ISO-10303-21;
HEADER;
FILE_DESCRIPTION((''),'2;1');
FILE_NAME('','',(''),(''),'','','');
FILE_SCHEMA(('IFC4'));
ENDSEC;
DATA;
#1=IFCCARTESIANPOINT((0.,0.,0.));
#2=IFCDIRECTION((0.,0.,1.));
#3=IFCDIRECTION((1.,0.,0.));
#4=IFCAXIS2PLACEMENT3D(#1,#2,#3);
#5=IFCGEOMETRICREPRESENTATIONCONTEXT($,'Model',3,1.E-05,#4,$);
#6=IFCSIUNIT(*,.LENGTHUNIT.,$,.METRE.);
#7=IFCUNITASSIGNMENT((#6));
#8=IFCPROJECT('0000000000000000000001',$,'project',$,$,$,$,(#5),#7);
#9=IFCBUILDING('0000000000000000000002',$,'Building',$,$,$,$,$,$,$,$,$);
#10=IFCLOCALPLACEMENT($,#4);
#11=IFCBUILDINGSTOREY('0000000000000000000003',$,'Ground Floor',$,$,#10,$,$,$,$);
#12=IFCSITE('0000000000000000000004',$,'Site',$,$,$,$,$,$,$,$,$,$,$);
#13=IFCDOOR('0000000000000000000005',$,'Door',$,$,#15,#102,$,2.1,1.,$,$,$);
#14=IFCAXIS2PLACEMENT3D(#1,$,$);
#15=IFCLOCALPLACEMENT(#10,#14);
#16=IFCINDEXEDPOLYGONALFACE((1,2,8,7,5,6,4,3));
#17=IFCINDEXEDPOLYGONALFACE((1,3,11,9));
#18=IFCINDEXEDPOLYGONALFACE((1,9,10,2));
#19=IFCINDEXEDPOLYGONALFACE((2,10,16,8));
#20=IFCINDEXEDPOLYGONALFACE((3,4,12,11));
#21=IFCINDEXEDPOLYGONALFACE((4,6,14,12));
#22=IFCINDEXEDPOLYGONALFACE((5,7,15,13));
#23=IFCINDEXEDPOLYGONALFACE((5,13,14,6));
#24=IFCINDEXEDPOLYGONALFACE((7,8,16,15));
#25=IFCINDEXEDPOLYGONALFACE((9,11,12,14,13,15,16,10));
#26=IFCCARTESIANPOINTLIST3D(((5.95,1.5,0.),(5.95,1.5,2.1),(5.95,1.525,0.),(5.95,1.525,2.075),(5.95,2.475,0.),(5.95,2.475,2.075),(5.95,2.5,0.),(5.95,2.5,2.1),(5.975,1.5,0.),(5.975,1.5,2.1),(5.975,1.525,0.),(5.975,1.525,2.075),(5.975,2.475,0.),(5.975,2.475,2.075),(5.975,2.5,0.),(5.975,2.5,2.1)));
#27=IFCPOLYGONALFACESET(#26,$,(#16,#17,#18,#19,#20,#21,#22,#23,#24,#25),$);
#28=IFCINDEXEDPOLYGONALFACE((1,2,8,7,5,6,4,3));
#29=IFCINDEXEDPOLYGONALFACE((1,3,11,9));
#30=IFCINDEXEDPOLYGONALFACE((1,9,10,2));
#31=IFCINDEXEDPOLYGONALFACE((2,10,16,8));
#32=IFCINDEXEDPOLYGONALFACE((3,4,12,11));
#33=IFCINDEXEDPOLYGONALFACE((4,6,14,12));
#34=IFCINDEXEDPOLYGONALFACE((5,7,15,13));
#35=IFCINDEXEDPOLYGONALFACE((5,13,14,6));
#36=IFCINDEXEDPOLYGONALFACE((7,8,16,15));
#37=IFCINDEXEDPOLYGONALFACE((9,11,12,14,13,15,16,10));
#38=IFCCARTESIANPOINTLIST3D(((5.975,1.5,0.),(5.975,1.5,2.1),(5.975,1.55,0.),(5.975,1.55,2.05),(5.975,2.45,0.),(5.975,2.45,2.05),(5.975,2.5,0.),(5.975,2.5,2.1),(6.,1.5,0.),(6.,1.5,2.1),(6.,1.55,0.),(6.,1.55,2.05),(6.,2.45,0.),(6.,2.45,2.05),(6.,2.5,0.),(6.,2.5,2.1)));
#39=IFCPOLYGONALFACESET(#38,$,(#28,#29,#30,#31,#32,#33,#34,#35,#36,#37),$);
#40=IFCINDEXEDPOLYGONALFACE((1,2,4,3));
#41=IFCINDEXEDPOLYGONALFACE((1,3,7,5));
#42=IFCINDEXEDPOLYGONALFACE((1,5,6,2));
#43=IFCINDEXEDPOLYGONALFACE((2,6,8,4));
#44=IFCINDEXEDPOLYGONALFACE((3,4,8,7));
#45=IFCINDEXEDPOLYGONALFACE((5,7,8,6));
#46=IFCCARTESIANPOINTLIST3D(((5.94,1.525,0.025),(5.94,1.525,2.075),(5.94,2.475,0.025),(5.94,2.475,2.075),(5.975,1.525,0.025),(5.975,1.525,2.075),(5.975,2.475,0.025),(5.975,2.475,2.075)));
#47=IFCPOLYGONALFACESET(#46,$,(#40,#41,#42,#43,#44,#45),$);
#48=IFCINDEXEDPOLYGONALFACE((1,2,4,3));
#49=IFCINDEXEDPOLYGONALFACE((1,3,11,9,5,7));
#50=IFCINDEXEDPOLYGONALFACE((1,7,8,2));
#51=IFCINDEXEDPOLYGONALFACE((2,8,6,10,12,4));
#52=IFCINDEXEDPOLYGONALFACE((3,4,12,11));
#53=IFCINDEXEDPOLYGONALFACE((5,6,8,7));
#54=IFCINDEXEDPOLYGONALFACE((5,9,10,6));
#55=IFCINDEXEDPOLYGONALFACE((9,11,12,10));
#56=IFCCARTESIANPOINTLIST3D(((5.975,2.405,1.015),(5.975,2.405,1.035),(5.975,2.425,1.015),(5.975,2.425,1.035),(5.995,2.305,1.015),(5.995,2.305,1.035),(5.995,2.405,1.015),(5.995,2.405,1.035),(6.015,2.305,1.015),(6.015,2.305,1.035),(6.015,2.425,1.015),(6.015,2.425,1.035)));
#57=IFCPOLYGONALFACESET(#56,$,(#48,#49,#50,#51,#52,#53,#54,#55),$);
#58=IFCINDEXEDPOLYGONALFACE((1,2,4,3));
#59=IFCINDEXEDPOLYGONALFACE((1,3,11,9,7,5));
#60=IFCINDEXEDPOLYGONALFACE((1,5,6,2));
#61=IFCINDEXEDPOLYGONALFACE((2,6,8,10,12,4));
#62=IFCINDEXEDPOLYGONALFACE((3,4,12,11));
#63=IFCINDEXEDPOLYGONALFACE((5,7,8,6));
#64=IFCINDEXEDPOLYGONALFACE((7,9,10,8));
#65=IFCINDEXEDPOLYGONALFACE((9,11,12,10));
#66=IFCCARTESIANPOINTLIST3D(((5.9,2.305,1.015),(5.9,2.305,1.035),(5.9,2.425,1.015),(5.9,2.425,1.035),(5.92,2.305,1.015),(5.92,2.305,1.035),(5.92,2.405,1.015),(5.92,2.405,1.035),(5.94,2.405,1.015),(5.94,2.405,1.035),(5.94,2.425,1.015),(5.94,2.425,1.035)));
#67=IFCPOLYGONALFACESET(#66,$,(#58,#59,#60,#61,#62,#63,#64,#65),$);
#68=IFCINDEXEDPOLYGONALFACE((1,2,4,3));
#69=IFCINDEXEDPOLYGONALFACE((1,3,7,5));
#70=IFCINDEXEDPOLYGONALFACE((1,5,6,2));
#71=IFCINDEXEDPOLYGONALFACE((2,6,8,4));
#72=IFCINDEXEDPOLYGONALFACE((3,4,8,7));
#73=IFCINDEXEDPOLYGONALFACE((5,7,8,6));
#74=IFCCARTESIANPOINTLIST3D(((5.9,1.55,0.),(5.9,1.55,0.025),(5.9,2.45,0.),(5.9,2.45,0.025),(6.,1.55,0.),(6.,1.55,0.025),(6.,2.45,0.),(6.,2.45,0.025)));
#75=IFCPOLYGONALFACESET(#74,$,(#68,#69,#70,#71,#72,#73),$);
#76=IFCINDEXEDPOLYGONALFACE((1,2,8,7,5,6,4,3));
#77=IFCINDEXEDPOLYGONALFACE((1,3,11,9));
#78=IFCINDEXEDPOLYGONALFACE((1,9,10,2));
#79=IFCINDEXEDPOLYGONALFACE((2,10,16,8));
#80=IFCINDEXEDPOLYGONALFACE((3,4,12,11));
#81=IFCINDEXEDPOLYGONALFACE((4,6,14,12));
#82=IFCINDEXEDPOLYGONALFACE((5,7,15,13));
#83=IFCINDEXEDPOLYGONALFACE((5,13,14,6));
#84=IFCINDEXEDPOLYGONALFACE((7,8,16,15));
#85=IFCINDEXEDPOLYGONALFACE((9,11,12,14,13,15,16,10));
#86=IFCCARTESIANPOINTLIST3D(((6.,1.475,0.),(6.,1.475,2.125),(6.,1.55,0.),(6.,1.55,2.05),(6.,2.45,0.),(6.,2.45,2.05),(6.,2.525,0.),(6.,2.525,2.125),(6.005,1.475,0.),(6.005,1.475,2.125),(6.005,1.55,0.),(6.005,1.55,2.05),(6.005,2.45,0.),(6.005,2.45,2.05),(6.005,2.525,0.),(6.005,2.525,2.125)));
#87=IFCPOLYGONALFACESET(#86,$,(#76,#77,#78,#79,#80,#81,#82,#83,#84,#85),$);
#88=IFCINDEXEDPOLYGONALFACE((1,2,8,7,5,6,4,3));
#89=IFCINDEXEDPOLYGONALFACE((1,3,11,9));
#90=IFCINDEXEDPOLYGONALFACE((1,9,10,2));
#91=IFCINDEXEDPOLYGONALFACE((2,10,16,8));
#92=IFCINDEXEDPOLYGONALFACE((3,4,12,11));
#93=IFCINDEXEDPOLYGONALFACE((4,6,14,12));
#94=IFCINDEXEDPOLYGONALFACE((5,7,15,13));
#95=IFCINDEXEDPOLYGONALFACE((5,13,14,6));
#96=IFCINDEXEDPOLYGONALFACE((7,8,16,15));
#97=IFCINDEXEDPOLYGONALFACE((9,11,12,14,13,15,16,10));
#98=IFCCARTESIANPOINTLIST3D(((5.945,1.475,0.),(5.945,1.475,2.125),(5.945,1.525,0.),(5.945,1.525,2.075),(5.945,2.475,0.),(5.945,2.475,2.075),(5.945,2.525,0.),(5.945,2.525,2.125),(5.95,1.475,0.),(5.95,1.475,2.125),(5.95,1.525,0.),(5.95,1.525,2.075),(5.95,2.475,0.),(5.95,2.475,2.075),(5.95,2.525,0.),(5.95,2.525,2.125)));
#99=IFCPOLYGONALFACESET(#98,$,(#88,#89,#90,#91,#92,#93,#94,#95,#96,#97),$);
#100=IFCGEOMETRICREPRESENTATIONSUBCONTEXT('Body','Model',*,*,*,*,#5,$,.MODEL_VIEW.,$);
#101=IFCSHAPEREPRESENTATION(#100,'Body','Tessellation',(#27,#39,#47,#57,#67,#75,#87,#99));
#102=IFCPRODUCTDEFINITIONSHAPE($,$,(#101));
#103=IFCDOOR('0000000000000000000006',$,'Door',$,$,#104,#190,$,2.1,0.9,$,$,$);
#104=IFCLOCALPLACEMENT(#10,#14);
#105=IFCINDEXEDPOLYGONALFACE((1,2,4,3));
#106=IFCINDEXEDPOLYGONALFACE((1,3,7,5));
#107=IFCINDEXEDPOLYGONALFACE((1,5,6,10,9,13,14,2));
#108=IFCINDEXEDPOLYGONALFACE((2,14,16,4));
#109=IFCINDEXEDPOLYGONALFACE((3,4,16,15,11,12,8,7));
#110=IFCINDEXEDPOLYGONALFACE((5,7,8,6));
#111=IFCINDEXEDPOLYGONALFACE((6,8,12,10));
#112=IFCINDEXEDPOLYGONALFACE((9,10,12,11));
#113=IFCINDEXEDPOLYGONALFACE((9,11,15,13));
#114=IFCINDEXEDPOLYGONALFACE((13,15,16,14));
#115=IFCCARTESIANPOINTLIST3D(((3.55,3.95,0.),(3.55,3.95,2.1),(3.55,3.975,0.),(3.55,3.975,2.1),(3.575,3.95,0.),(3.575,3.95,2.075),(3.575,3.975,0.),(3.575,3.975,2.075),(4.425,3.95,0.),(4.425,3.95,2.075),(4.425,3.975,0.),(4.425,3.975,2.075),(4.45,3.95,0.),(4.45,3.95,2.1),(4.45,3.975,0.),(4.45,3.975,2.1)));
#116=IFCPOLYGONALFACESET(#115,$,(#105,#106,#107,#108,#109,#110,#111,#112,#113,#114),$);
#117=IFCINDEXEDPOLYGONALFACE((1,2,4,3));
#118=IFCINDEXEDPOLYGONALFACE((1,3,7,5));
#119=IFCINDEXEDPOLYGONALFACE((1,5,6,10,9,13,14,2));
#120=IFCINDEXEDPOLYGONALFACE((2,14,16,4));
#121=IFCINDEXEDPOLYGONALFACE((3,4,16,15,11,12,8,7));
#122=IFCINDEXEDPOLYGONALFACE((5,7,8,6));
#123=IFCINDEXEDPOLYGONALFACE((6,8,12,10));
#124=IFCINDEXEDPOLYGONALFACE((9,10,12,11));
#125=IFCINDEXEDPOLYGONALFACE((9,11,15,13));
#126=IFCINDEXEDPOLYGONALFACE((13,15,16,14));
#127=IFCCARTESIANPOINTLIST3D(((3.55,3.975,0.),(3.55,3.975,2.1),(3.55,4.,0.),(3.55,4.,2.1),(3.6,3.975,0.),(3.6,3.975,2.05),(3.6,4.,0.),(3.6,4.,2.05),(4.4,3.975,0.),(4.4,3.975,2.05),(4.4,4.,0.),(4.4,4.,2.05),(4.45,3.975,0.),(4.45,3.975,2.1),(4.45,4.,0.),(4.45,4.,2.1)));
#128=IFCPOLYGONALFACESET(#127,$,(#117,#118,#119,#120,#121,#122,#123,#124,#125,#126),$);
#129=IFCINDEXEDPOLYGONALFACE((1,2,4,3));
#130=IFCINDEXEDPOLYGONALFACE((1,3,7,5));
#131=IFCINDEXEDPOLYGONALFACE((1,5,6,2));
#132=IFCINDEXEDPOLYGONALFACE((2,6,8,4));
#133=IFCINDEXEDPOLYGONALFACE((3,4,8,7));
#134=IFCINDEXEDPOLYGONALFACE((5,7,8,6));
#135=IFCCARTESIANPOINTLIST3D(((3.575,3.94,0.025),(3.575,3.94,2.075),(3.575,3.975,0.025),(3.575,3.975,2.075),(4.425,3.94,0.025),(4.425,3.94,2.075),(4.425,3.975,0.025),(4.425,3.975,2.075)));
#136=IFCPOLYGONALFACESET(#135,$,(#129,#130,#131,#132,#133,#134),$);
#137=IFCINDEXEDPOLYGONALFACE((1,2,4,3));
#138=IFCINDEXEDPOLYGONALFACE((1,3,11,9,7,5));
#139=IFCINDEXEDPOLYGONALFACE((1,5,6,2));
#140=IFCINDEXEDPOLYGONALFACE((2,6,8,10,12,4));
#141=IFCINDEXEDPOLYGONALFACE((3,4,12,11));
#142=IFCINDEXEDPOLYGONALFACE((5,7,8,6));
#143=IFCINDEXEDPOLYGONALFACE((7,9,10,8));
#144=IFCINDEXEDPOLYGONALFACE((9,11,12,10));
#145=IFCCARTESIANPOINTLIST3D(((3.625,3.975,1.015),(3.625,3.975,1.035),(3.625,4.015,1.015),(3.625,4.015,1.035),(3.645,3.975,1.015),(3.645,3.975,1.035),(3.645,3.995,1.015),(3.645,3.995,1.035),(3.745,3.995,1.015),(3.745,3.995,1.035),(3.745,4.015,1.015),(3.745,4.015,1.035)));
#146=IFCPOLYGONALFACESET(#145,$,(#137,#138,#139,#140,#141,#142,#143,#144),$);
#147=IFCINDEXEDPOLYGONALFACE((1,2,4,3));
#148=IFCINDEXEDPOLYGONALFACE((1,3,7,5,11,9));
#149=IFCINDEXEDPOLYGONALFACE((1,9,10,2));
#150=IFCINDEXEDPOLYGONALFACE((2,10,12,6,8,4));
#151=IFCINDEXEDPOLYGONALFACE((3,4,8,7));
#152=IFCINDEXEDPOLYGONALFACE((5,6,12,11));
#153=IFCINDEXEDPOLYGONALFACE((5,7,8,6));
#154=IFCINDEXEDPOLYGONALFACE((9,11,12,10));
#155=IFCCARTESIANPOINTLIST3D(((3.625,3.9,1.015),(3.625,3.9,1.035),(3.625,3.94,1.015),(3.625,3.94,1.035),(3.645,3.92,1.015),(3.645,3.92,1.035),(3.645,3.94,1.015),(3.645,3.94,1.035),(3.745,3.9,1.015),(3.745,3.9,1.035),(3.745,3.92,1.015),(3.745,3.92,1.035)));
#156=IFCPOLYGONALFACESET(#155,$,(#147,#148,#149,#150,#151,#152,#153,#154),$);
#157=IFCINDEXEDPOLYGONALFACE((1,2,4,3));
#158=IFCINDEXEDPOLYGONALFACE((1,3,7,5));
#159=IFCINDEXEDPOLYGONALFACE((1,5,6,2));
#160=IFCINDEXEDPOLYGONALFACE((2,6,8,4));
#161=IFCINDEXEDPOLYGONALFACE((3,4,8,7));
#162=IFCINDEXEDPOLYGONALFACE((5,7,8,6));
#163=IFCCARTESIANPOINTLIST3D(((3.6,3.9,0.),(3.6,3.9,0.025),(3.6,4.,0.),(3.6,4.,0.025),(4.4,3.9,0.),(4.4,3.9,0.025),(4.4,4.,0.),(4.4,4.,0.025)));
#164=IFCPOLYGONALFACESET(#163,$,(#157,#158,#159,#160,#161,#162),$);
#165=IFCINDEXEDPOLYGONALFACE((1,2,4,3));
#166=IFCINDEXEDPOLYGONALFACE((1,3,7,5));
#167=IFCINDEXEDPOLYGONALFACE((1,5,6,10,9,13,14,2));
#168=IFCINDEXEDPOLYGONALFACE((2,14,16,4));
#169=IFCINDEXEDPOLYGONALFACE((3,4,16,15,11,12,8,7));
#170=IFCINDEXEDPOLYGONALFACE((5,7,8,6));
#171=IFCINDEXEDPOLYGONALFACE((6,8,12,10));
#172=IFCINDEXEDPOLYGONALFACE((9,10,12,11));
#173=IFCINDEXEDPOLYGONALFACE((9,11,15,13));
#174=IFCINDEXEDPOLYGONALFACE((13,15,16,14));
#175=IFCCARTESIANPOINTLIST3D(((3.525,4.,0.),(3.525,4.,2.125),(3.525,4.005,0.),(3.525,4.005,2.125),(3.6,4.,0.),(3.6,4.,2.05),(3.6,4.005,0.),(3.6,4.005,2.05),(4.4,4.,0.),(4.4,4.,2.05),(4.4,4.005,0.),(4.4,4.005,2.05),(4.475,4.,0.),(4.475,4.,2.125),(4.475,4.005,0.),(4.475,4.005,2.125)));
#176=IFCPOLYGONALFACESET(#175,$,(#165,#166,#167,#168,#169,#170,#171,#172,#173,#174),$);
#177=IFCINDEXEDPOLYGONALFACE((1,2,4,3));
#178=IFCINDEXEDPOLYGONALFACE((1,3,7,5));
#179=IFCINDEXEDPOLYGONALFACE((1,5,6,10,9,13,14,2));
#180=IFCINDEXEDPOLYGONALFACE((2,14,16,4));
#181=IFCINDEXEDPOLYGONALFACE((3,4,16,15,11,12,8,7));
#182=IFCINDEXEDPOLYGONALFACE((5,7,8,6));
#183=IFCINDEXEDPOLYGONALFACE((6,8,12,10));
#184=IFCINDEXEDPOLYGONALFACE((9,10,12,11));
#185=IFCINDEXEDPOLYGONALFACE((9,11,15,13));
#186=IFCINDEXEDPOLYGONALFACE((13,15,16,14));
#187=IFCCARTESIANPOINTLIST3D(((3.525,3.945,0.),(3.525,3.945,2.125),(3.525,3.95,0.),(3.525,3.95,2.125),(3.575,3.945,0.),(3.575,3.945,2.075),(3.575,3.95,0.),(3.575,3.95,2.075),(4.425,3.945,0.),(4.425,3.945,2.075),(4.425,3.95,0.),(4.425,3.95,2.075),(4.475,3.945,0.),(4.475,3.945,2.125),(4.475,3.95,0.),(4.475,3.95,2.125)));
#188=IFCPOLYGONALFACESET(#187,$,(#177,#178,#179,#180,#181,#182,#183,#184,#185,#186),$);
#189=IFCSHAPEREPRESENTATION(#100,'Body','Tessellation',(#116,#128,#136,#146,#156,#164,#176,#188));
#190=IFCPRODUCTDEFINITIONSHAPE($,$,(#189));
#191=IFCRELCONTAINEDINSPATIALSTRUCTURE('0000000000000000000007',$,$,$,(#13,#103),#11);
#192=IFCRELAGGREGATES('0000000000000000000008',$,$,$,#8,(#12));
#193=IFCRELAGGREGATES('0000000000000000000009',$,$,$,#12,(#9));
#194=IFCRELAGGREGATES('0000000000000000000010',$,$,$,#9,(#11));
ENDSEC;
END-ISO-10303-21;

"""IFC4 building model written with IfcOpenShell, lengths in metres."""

from ifc_helpers import new_model, si_unit, frame, origin_with_axes, place, context, subcontext, project, spatial, line, indexed_curve, outline, extrude, element, save


model = new_model("IFC4")

# Units and contexts
model_context = context("Model", 3, precision=1e-05, world=origin_with_axes())
body_context = subcontext(model_context, "Body", "Model", "MODEL_VIEW")
ifc_project = project(units=[si_unit("LENGTHUNIT", "METRE")], contexts=[model_context])

# Site, building, storey
site = spatial("IfcSite", under=ifc_project, Name="Site")
building = spatial("IfcBuilding", under=site, Name="Building")
storey_placement = place(None, origin_with_axes())
storey = spatial("IfcBuildingStorey", under=building, at=storey_placement, Name="Ground Floor")

# Doors
door_1_placement = place(storey_placement, frame((6.0, 1.5, 0.0), z_axis=(0.0, 0.0, 1.0), x_axis=(0.0, 1.0, 0.0)))
element("IfcDoor", 1, at=door_1_placement, inside=storey, Name="Door", OverallHeight=2.1, OverallWidth=1.0, context=body_context, shape_type="SweptSolid", body=[
    extrude(outline(indexed_curve([(0.0, 0.0), (0.0, 2.1), (1.0, 2.1), (1.0, 0.0), (0.975, 0.0), (0.975, 2.075), (0.025, 2.075), (0.025, 0.0)], segments=[line(1, 2, 3, 4, 5, 6, 7, 8, 1)])), frame((0.0, 0.025, 0.0), z_axis=(0.0, -1.0, 0.0), x_axis=(1.0, 0.0, 0.0)), (0.0, 0.0, -1.0), 0.025),
    extrude(outline(indexed_curve([(0.0, 0.0), (0.0, 2.1), (1.0, 2.1), (1.0, 0.0), (0.95, 0.0), (0.95, 2.05), (0.05, 2.05), (0.05, 0.0)], segments=[line(1, 2, 3, 4, 5, 6, 7, 8, 1)])), frame((0.0, 0.0, 0.0), z_axis=(0.0, -1.0, 0.0), x_axis=(1.0, 0.0, 0.0)), (0.0, 0.0, -1.0), 0.025),
    extrude(outline(indexed_curve([(0.0, 0.0), (0.95, 0.0), (0.95, 0.035), (0.0, 0.035)], segments=[line(1, 2, 3, 4, 1)])), frame((0.025, 0.025, 0.025), z_axis=(0.0, 0.0, 1.0), x_axis=(1.0, 0.0, 0.0)), (0.0, 0.0, 1.0), 2.05),
    extrude(outline(indexed_curve([(0.0, 0.0), (0.0, -0.04), (-0.12, -0.04), (-0.12, -0.02), (-0.02, -0.02), (-0.02, 0.0)], segments=[line(1, 2, 3, 4, 5, 6, 1)])), frame((0.925, 0.025, 1.015), z_axis=(0.0, 0.0, 1.0), x_axis=(1.0, 0.0, 0.0)), (0.0, 0.0, 1.0), 0.02),
    extrude(outline(indexed_curve([(0.0, 0.0), (0.0, 0.04), (-0.12, 0.04), (-0.12, 0.02), (-0.02, 0.02), (-0.02, 0.0)], segments=[line(1, 2, 3, 4, 5, 6, 1)])), frame((0.925, 0.06, 1.015), z_axis=(0.0, 0.0, 1.0), x_axis=(1.0, 0.0, 0.0)), (0.0, 0.0, 1.0), 0.02),
    extrude(outline(indexed_curve([(0.0, 0.0), (0.9, 0.0), (0.9, 0.1), (0.0, 0.1)], segments=[line(1, 2, 3, 4, 1)])), frame((0.05, 0.0, 0.0), z_axis=(0.0, 0.0, 1.0), x_axis=(1.0, 0.0, 0.0)), (0.0, 0.0, 1.0), 0.025),
    extrude(outline(indexed_curve([(0.0, 0.0), (0.0, 2.125), (1.05, 2.125), (1.05, 0.0), (0.975, 0.0), (0.975, 2.05), (0.075, 2.05), (0.075, 0.0)], segments=[line(1, 2, 3, 4, 5, 6, 7, 8, 1)])), frame((-0.025, -0.005, 0.0), z_axis=(0.0, -1.0, 0.0), x_axis=(1.0, 0.0, 0.0)), (0.0, 0.0, -1.0), 0.005),
    extrude(outline(indexed_curve([(0.0, 0.0), (0.0, 2.125), (1.05, 2.125), (1.05, 0.0), (1.0, 0.0), (1.0, 2.075), (0.05, 2.075), (0.05, 0.0)], segments=[line(1, 2, 3, 4, 5, 6, 7, 8, 1)])), frame((-0.025, 0.05, 0.0), z_axis=(0.0, -1.0, 0.0), x_axis=(1.0, 0.0, 0.0)), (0.0, 0.0, -1.0), 0.005),
])
door_2_placement = place(storey_placement, frame((4.45, 4.0, 0.0), z_axis=(0.0, 0.0, 1.0), x_axis=(-1.0, 0.0, 0.0)))
element("IfcDoor", 2, at=door_2_placement, inside=storey, Name="Door", OverallHeight=2.1, OverallWidth=0.9, context=body_context, shape_type="SweptSolid", body=[
    extrude(outline(indexed_curve([(0.0, 0.0), (0.0, 2.1), (0.9, 2.1), (0.9, 0.0), (0.875, 0.0), (0.875, 2.075), (0.025, 2.075), (0.025, 0.0)], segments=[line(1, 2, 3, 4, 5, 6, 7, 8, 1)])), frame((0.0, 0.025, 0.0), z_axis=(0.0, -1.0, 0.0), x_axis=(1.0, 0.0, 0.0)), (0.0, 0.0, -1.0), 0.025),
    extrude(outline(indexed_curve([(0.0, 0.0), (0.0, 2.1), (0.9, 2.1), (0.9, 0.0), (0.85, 0.0), (0.85, 2.05), (0.05, 2.05), (0.05, 0.0)], segments=[line(1, 2, 3, 4, 5, 6, 7, 8, 1)])), frame((0.0, 0.0, 0.0), z_axis=(0.0, -1.0, 0.0), x_axis=(1.0, 0.0, 0.0)), (0.0, 0.0, -1.0), 0.025),
    extrude(outline(indexed_curve([(0.0, 0.0), (0.85, 0.0), (0.85, 0.035), (0.0, 0.035)], segments=[line(1, 2, 3, 4, 1)])), frame((0.025, 0.025, 0.025), z_axis=(0.0, 0.0, 1.0), x_axis=(1.0, 0.0, 0.0)), (0.0, 0.0, 1.0), 2.05),
    extrude(outline(indexed_curve([(0.0, 0.0), (0.0, -0.04), (-0.12, -0.04), (-0.12, -0.02), (-0.02, -0.02), (-0.02, 0.0)], segments=[line(1, 2, 3, 4, 5, 6, 1)])), frame((0.825, 0.025, 1.015), z_axis=(0.0, 0.0, 1.0), x_axis=(1.0, 0.0, 0.0)), (0.0, 0.0, 1.0), 0.02),
    extrude(outline(indexed_curve([(0.0, 0.0), (0.0, 0.04), (-0.12, 0.04), (-0.12, 0.02), (-0.02, 0.02), (-0.02, 0.0)], segments=[line(1, 2, 3, 4, 5, 6, 1)])), frame((0.825, 0.06, 1.015), z_axis=(0.0, 0.0, 1.0), x_axis=(1.0, 0.0, 0.0)), (0.0, 0.0, 1.0), 0.02),
    extrude(outline(indexed_curve([(0.0, 0.0), (0.8, 0.0), (0.8, 0.1), (0.0, 0.1)], segments=[line(1, 2, 3, 4, 1)])), frame((0.05, 0.0, 0.0), z_axis=(0.0, 0.0, 1.0), x_axis=(1.0, 0.0, 0.0)), (0.0, 0.0, 1.0), 0.025),
    extrude(outline(indexed_curve([(0.0, 0.0), (0.0, 2.125), (0.95, 2.125), (0.95, 0.0), (0.875, 0.0), (0.875, 2.05), (0.075, 2.05), (0.075, 0.0)], segments=[line(1, 2, 3, 4, 5, 6, 7, 8, 1)])), frame((-0.025, -0.005, 0.0), z_axis=(0.0, -1.0, 0.0), x_axis=(1.0, 0.0, 0.0)), (0.0, 0.0, -1.0), 0.005),
    extrude(outline(indexed_curve([(0.0, 0.0), (0.0, 2.125), (0.95, 2.125), (0.95, 0.0), (0.9, 0.0), (0.9, 2.075), (0.05, 2.075), (0.05, 0.0)], segments=[line(1, 2, 3, 4, 5, 6, 7, 8, 1)])), frame((-0.025, 0.05, 0.0), z_axis=(0.0, -1.0, 0.0), x_axis=(1.0, 0.0, 0.0)), (0.0, 0.0, -1.0), 0.005),
])

save(model, "model.ifc")
